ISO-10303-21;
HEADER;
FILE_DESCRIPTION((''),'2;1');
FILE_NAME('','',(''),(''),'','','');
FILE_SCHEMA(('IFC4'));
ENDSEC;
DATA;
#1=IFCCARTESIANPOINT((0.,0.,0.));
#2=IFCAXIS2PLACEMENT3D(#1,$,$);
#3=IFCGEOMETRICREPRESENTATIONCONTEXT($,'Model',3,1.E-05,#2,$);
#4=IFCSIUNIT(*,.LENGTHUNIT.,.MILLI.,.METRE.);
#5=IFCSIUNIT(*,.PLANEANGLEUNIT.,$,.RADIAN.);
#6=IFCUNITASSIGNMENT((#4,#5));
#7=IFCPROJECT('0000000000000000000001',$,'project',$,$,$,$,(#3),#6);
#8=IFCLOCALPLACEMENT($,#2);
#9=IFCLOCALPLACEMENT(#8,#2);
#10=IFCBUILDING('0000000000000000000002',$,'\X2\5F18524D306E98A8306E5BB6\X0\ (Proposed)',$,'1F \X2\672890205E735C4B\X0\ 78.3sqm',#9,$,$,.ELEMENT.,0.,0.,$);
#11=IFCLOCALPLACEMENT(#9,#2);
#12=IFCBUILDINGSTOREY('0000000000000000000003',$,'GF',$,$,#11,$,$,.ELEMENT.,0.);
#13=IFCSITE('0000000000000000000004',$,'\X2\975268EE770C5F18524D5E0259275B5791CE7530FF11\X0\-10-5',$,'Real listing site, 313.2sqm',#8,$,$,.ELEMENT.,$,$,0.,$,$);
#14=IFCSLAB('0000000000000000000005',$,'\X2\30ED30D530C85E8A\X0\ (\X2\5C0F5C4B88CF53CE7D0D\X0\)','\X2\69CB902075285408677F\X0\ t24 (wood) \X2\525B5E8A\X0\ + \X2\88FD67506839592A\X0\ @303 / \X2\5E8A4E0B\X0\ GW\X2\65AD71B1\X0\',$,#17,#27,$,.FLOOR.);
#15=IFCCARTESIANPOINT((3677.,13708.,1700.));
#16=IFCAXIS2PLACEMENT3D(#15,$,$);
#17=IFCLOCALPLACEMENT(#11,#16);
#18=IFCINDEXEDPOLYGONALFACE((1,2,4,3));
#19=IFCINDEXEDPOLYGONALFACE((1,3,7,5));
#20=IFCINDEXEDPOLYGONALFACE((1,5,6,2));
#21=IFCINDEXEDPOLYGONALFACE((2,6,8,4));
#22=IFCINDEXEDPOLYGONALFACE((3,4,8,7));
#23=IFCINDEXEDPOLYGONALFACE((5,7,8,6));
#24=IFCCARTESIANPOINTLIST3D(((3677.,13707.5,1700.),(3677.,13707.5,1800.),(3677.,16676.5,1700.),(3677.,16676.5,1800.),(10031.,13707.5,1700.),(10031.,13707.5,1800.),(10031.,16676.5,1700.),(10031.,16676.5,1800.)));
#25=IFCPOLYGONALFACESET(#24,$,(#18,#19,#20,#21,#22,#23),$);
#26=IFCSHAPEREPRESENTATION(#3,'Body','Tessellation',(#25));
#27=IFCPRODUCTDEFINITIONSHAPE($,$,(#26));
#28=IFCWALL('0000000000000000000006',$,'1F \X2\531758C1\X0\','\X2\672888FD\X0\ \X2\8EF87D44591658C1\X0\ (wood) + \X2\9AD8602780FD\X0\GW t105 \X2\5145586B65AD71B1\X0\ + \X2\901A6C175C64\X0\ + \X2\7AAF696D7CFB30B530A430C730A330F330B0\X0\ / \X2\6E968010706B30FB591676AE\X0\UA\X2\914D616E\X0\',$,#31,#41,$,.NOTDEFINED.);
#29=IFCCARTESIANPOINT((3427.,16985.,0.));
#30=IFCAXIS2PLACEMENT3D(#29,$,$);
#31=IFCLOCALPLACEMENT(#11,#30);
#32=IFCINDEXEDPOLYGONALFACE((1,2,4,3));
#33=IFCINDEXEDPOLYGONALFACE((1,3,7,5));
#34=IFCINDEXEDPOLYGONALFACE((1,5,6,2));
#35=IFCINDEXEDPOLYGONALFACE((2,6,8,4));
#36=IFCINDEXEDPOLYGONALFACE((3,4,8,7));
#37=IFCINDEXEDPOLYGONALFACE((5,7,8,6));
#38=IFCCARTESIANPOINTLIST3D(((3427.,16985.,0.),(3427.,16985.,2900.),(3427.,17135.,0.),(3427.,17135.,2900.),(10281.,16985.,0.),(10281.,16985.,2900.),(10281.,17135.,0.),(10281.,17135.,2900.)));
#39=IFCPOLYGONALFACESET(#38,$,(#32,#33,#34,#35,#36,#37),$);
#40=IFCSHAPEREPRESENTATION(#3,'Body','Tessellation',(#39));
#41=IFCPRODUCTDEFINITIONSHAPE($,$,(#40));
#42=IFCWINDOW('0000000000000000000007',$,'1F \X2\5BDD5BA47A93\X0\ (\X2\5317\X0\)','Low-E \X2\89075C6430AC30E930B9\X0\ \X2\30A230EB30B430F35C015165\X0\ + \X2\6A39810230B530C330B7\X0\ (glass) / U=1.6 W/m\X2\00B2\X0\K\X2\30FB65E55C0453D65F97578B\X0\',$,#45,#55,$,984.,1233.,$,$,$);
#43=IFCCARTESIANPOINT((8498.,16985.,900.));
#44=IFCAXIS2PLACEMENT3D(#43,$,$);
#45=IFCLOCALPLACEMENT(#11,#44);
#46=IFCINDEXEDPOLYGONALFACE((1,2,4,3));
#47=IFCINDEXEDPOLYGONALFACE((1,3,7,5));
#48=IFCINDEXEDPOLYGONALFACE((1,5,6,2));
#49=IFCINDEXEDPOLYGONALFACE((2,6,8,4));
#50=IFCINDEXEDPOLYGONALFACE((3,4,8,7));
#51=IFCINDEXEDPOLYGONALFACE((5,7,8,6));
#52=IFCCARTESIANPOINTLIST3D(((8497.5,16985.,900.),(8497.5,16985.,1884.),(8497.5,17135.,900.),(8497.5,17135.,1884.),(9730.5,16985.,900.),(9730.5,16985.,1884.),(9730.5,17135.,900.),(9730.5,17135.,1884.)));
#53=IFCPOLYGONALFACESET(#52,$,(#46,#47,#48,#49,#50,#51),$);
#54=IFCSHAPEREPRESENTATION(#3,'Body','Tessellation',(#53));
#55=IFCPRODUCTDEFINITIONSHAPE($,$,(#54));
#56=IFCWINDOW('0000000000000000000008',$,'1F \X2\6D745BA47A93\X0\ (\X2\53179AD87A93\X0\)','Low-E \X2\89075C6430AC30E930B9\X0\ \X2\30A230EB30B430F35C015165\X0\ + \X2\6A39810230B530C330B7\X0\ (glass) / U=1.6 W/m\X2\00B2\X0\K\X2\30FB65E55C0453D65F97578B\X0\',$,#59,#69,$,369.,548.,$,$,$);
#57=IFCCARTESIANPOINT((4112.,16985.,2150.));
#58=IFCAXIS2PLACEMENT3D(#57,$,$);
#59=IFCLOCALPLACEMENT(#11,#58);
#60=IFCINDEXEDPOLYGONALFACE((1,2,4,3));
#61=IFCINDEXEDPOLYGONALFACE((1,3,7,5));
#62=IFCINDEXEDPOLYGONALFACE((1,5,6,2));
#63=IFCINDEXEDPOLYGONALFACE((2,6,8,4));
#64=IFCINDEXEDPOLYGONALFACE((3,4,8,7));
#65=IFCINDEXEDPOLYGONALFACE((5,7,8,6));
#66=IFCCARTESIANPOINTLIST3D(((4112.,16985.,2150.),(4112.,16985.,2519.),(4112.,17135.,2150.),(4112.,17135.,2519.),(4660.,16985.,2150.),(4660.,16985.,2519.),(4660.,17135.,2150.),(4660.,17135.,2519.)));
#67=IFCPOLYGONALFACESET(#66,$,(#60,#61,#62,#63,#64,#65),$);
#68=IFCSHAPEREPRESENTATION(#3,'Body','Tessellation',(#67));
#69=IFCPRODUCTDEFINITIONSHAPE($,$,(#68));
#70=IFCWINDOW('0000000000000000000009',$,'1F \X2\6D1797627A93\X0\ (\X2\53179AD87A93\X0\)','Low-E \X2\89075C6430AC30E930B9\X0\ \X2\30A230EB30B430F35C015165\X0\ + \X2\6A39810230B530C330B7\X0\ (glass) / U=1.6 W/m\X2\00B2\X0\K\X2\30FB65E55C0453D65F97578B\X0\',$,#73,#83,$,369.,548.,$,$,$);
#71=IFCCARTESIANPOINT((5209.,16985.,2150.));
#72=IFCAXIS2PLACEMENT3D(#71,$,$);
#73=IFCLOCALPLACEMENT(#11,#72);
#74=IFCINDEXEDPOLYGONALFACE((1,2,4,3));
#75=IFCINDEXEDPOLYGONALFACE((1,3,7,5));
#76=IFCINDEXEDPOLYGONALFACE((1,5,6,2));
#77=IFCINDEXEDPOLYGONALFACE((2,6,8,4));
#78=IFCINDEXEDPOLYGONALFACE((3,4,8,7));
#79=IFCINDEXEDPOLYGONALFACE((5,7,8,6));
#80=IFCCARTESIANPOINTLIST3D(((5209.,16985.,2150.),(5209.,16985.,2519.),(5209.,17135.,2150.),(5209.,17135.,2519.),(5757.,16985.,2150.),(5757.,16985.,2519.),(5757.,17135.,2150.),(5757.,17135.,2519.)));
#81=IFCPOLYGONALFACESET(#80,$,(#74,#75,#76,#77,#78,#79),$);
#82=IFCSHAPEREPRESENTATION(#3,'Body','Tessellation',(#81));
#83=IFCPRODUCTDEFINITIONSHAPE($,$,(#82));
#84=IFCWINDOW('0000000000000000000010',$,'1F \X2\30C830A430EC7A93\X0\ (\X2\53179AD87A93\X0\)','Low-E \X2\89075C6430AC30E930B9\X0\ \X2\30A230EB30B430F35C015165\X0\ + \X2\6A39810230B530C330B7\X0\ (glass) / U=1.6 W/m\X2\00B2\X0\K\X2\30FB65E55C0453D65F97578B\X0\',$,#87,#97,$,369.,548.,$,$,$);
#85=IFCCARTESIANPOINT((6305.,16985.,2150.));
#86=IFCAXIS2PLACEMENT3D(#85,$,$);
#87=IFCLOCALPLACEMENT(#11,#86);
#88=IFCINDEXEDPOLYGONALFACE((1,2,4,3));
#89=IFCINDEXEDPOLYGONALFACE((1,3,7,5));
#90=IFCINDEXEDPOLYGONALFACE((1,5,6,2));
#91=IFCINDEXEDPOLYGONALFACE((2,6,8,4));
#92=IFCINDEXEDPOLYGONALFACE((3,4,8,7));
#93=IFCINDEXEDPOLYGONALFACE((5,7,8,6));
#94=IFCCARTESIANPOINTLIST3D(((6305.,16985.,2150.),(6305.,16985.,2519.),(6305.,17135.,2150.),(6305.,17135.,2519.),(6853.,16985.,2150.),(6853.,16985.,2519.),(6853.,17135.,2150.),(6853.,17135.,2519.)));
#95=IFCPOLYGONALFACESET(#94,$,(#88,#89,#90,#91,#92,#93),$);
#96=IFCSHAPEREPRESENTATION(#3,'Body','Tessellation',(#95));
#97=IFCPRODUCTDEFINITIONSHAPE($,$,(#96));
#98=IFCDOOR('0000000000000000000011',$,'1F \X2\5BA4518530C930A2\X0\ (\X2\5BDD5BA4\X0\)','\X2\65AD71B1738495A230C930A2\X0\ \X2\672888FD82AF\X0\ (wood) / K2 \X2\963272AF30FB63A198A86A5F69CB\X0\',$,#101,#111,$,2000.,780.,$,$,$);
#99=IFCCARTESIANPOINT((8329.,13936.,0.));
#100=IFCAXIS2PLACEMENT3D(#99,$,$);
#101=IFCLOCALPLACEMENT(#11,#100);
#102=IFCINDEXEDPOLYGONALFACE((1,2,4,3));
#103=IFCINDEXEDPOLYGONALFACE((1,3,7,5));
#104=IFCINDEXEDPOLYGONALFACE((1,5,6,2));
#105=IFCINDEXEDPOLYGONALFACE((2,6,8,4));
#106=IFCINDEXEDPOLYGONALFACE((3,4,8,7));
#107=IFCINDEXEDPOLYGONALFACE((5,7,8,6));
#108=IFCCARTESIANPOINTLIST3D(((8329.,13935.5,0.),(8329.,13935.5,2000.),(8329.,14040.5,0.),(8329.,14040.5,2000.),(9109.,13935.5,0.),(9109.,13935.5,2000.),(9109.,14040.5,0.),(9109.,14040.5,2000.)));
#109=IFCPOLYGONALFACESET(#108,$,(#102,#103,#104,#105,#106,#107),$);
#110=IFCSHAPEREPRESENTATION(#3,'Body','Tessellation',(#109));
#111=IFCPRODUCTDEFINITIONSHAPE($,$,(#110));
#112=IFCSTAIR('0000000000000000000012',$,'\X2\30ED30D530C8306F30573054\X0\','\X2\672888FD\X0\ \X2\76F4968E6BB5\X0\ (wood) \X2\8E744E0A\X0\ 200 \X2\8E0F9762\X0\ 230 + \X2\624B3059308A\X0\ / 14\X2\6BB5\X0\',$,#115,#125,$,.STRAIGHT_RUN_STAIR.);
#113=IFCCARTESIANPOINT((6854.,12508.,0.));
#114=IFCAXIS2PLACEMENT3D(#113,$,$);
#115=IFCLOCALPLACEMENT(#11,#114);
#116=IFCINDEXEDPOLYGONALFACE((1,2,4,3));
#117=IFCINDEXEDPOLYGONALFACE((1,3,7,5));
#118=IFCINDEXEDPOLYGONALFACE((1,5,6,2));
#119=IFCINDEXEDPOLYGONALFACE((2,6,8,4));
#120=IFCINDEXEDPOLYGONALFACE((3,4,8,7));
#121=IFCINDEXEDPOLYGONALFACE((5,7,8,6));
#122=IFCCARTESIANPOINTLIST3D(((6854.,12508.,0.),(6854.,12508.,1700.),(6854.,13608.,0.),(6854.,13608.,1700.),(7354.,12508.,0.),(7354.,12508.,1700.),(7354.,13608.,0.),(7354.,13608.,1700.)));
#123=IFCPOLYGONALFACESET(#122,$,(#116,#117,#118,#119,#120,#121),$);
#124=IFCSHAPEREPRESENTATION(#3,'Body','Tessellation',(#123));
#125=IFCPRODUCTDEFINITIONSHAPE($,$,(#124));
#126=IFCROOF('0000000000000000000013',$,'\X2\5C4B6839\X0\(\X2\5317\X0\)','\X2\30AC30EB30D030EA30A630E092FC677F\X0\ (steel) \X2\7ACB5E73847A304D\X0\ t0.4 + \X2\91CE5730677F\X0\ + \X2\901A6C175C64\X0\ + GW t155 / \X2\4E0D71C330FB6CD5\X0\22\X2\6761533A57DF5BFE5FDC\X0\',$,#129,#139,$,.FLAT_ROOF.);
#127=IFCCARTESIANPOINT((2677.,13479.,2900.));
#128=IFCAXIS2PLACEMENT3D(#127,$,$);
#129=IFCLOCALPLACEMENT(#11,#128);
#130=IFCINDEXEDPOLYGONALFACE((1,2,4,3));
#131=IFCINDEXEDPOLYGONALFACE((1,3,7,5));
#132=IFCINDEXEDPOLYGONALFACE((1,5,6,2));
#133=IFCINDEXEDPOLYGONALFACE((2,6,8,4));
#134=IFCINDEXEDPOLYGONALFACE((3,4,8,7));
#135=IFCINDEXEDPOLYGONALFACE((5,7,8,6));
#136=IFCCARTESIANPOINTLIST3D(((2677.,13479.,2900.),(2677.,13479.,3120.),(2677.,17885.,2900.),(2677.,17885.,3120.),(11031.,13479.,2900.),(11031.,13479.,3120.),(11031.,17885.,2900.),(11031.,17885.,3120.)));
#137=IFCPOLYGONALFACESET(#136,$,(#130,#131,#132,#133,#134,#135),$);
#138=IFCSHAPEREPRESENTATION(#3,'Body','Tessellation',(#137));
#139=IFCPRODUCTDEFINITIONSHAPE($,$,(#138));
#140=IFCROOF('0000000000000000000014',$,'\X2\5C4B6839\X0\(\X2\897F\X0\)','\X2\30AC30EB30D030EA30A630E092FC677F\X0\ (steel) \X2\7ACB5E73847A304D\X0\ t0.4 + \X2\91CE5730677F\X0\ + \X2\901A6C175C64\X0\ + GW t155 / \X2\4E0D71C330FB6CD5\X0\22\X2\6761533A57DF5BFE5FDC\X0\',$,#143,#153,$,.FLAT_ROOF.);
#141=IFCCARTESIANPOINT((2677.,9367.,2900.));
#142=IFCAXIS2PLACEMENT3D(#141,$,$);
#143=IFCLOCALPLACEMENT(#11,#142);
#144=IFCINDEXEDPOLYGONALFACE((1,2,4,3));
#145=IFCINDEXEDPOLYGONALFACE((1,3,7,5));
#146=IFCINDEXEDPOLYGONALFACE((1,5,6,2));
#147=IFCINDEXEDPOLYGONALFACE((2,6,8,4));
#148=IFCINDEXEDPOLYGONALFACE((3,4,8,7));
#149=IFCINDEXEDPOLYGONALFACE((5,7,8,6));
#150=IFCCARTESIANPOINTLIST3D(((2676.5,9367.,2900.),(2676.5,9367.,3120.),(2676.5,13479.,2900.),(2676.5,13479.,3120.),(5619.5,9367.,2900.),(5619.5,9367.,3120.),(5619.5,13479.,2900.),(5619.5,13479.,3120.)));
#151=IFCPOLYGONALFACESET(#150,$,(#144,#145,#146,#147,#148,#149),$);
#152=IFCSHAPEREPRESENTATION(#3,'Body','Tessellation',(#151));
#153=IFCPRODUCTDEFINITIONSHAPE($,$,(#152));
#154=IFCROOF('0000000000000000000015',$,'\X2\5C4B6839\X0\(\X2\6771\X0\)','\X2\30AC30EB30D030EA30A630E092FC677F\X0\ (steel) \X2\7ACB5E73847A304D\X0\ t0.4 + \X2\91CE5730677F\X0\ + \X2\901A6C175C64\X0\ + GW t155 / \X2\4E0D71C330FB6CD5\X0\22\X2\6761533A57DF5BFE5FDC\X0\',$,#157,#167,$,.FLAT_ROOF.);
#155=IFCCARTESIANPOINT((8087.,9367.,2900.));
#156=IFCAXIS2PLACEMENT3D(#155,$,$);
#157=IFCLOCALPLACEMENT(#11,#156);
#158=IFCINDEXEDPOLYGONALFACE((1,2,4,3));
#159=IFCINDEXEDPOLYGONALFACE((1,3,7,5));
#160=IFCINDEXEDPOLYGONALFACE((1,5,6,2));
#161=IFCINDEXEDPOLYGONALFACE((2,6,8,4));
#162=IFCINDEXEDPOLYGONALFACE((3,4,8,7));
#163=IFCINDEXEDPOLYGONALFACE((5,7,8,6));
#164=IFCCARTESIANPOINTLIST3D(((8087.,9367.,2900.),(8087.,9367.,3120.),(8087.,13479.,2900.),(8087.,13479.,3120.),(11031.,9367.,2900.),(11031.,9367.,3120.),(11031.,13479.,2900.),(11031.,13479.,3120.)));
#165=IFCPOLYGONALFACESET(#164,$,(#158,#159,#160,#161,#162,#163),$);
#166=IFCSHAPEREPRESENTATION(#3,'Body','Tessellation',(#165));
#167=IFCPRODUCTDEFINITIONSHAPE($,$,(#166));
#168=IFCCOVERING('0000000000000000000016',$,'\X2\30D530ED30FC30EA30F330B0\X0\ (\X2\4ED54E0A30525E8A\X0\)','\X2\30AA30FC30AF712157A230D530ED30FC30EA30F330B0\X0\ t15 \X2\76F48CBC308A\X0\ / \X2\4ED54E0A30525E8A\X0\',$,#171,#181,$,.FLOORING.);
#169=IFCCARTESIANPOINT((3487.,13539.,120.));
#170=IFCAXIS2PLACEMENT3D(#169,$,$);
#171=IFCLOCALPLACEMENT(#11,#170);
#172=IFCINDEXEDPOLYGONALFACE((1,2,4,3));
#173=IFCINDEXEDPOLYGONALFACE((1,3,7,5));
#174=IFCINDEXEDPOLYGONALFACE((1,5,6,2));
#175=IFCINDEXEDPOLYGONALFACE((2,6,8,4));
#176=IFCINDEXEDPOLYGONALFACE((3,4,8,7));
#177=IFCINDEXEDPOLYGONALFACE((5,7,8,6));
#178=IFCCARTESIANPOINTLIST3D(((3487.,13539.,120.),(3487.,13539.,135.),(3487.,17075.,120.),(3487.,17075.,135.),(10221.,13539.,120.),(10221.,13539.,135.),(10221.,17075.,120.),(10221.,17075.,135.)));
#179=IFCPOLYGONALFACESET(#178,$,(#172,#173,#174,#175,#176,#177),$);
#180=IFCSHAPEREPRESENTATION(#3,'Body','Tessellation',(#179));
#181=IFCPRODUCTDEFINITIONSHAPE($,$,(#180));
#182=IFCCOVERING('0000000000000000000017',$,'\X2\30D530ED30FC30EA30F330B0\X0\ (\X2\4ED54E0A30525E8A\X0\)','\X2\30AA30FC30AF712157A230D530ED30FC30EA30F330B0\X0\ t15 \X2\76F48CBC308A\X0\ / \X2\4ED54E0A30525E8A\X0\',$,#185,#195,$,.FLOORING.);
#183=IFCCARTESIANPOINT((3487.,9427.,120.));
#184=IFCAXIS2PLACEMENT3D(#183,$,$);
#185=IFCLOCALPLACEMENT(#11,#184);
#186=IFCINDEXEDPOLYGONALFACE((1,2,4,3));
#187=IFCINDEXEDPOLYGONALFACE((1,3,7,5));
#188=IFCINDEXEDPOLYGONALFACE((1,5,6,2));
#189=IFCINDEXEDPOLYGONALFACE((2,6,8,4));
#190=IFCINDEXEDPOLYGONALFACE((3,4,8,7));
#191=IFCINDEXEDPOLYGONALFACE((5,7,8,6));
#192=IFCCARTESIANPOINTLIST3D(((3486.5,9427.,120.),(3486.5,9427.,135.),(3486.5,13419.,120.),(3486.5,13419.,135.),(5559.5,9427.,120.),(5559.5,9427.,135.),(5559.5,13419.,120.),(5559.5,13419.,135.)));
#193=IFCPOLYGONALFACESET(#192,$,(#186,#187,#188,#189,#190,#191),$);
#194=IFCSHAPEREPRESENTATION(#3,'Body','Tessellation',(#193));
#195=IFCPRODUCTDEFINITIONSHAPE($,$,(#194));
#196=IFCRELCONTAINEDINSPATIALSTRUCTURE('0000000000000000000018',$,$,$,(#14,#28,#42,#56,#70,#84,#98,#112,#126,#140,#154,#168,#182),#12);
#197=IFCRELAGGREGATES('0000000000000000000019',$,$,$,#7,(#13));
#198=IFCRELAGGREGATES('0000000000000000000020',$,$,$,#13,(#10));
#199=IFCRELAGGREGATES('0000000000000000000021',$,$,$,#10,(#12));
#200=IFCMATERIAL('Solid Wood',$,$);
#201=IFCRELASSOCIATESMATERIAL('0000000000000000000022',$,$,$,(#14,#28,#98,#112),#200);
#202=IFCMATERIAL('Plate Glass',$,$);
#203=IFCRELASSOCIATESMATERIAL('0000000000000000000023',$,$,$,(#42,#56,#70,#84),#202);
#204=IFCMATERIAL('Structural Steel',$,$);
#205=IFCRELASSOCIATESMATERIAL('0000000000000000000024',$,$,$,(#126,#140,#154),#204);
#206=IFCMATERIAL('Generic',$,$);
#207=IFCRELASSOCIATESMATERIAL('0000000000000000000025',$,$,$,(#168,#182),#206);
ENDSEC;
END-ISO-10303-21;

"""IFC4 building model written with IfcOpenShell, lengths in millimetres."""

from ifc_helpers import new_model, si_unit, frame, frame_2d, origin, place, context, project, spatial, rectangle, extrude, material, element, fill, save


model = new_model("IFC4")

# Units and contexts
model_context = context("Model", 3, precision=1e-05, world=origin())
ifc_project = project(units=[si_unit("LENGTHUNIT", "METRE", prefix="MILLI"), si_unit("PLANEANGLEUNIT", "RADIAN")], contexts=[model_context])

# Site, building, storey
site_placement = place(None, origin())
site = spatial("IfcSite", under=ifc_project, at=site_placement, Name="青森県弘前市大字野田１-10-5", ObjectType="Real listing site, 313.2sqm", CompositionType="ELEMENT", RefElevation=0.0)
building_placement = place(site_placement, origin())
building = spatial("IfcBuilding", under=site, at=building_placement, Name="弘前の風の家 (Proposed)", ObjectType="1F 木造平屋 78.3sqm", CompositionType="ELEMENT", ElevationOfRefHeight=0.0, ElevationOfTerrain=0.0)
storey_placement = place(building_placement, origin())
storey = spatial("IfcBuildingStorey", under=building, at=storey_placement, Name="GF", CompositionType="ELEMENT", Elevation=0.0)

# Slab
ifc_material_1 = material(Name="Solid Wood")
slab_1_placement = place(storey_placement, frame((3677.0, 13708.0, 1700.0)))
element("IfcSlab", 1, at=slab_1_placement, inside=storey, material=ifc_material_1, Name="ロフト床 (小屋裏収納)", Description="構造用合板 t24 (wood) 剛床 + 製材根太 @303 / 床下 GW断熱", PredefinedType="FLOOR", context=model_context, shape_type="SweptSolid", body=[
    extrude(rectangle(XDim=6354.0, YDim=2969.0, at=frame_2d((3177.0, 1484.0))), frame((3677.0, 13708.0, 1700.0)), (0.0, 0.0, 1.0), 100.0),
])

# Wall, openings, windows
wall_1_placement = place(storey_placement, frame((3427.0, 16985.0, 0.0)))
wall_1 = element("IfcWall", 2, at=wall_1_placement, inside=storey, material=ifc_material_1, Name="1F 北壁", Description="木製 軸組外壁 (wood) + 高性能GW t105 充填断熱 + 通気層 + 窯業系サイディング / 準耐火・外皮UA配慮", PredefinedType="NOTDEFINED", context=model_context, shape_type="SweptSolid", body=[
    extrude(rectangle(XDim=6854.0, YDim=150.0, at=frame_2d((3427.0, 75.0))), frame((3427.0, 16985.0, 0.0)), (0.0, 0.0, 1.0), 2900.0),
])
opening_1_placement = place(storey_placement, frame((8498.0, 16985.0, 900.0)))
opening_1 = element("IfcOpeningElement", 3, at=opening_1_placement, cuts=wall_1, PredefinedType="NOTDEFINED", context=model_context, shape_type="SweptSolid", body=[
    extrude(rectangle(XDim=1233.0, YDim=150.0, at=frame_2d((616.0, 75.0))), frame((8498.0, 16985.0, 900.0)), (0.0, 0.0, 1.0), 984.0),
])
opening_2_placement = place(storey_placement, frame((4112.0, 16985.0, 2150.0)))
opening_2 = element("IfcOpeningElement", 4, at=opening_2_placement, cuts=wall_1, PredefinedType="NOTDEFINED", context=model_context, shape_type="SweptSolid", body=[
    extrude(rectangle(XDim=548.0, YDim=150.0, at=frame_2d((274.0, 75.0))), frame((4112.0, 16985.0, 2150.0)), (0.0, 0.0, 1.0), 369.0),
])
opening_3_placement = place(storey_placement, frame((5209.0, 16985.0, 2150.0)))
opening_3 = element("IfcOpeningElement", 5, at=opening_3_placement, cuts=wall_1, PredefinedType="NOTDEFINED", context=model_context, shape_type="SweptSolid", body=[
    extrude(rectangle(XDim=548.0, YDim=150.0, at=frame_2d((274.0, 75.0))), frame((5209.0, 16985.0, 2150.0)), (0.0, 0.0, 1.0), 369.0),
])
opening_4_placement = place(storey_placement, frame((6305.0, 16985.0, 2150.0)))
opening_4 = element("IfcOpeningElement", 6, at=opening_4_placement, cuts=wall_1, PredefinedType="NOTDEFINED", context=model_context, shape_type="SweptSolid", body=[
    extrude(rectangle(XDim=548.0, YDim=150.0, at=frame_2d((274.0, 75.0))), frame((6305.0, 16985.0, 2150.0)), (0.0, 0.0, 1.0), 369.0),
])
ifc_material_2 = material(Name="Plate Glass")
window_1_placement = place(storey_placement, frame((8498.0, 16985.0, 900.0)))
window_1 = element("IfcWindow", 7, at=window_1_placement, inside=storey, material=ifc_material_2, Name="1F 寝室窓 (北)", Description="Low-E 複層ガラス アルゴン封入 + 樹脂サッシ (glass) / U=1.6 W/m²K・日射取得型", OverallHeight=984.0, OverallWidth=1233.0, context=model_context, shape_type="SweptSolid", body=[
    extrude(rectangle(XDim=1233.0, YDim=150.0, at=frame_2d((616.0, 75.0))), frame((8498.0, 16985.0, 900.0)), (0.0, 0.0, 1.0), 984.0),
])
fill(opening_1, window_1)
window_2_placement = place(storey_placement, frame((4112.0, 16985.0, 2150.0)))
window_2 = element("IfcWindow", 8, at=window_2_placement, inside=storey, material=ifc_material_2, Name="1F 浴室窓 (北高窓)", Description="Low-E 複層ガラス アルゴン封入 + 樹脂サッシ (glass) / U=1.6 W/m²K・日射取得型", OverallHeight=369.0, OverallWidth=548.0, context=model_context, shape_type="SweptSolid", body=[
    extrude(rectangle(XDim=548.0, YDim=150.0, at=frame_2d((274.0, 75.0))), frame((4112.0, 16985.0, 2150.0)), (0.0, 0.0, 1.0), 369.0),
])
fill(opening_2, window_2)
window_3_placement = place(storey_placement, frame((5209.0, 16985.0, 2150.0)))
window_3 = element("IfcWindow", 9, at=window_3_placement, inside=storey, material=ifc_material_2, Name="1F 洗面窓 (北高窓)", Description="Low-E 複層ガラス アルゴン封入 + 樹脂サッシ (glass) / U=1.6 W/m²K・日射取得型", OverallHeight=369.0, OverallWidth=548.0, context=model_context, shape_type="SweptSolid", body=[
    extrude(rectangle(XDim=548.0, YDim=150.0, at=frame_2d((274.0, 75.0))), frame((5209.0, 16985.0, 2150.0)), (0.0, 0.0, 1.0), 369.0),
])
fill(opening_3, window_3)
window_4_placement = place(storey_placement, frame((6305.0, 16985.0, 2150.0)))
window_4 = element("IfcWindow", 10, at=window_4_placement, inside=storey, material=ifc_material_2, Name="1F トイレ窓 (北高窓)", Description="Low-E 複層ガラス アルゴン封入 + 樹脂サッシ (glass) / U=1.6 W/m²K・日射取得型", OverallHeight=369.0, OverallWidth=548.0, context=model_context, shape_type="SweptSolid", body=[
    extrude(rectangle(XDim=548.0, YDim=150.0, at=frame_2d((274.0, 75.0))), frame((6305.0, 16985.0, 2150.0)), (0.0, 0.0, 1.0), 369.0),
])
fill(opening_4, window_4)

# Door
door_1_placement = place(storey_placement, frame((8329.0, 13936.0, 0.0)))
element("IfcDoor", 11, at=door_1_placement, inside=storey, material=ifc_material_1, Name="1F 室内ドア (寝室)", Description="断熱玄関ドア 木製芯 (wood) / K2 防犯・採風機構", OverallHeight=2000.0, OverallWidth=780.0, context=model_context, shape_type="SweptSolid", body=[
    extrude(rectangle(XDim=780.0, YDim=105.0, at=frame_2d((390.0, 52.0))), frame((8329.0, 13936.0, 0.0)), (0.0, 0.0, 1.0), 2000.0),
])

# Stair
stair_placement = place(storey_placement, frame((6854.0, 12508.0, 0.0)))
element("IfcStair", 12, at=stair_placement, inside=storey, material=ifc_material_1, Name="ロフトはしご", Description="木製 直階段 (wood) 蹴上 200 踏面 230 + 手すり / 14段", PredefinedType="STRAIGHT_RUN_STAIR", context=model_context, shape_type="SweptSolid", body=[
    extrude(rectangle(XDim=500.0, YDim=1100.0, at=frame_2d((250.0, 550.0))), frame((6854.0, 12508.0, 0.0)), (0.0, 0.0, 1.0), 1700.0),
])

# Roofs
ifc_material_3 = material(Name="Structural Steel")
roof_1_placement = place(storey_placement, frame((2677.0, 13479.0, 2900.0)))
element("IfcRoof", 13, at=roof_1_placement, inside=storey, material=ifc_material_3, Name="屋根(北)", Description="ガルバリウム鋼板 (steel) 立平葺き t0.4 + 野地板 + 通気層 + GW t155 / 不燃・法22条区域対応", PredefinedType="FLAT_ROOF", context=model_context, shape_type="SweptSolid", body=[
    extrude(rectangle(XDim=8354.0, YDim=4406.0, at=frame_2d((4177.0, 2203.0))), frame((2677.0, 13479.0, 2900.0)), (0.0, 0.0, 1.0), 220.0),
])
roof_2_placement = place(storey_placement, frame((2677.0, 9367.0, 2900.0)))
element("IfcRoof", 14, at=roof_2_placement, inside=storey, material=ifc_material_3, Name="屋根(西)", Description="ガルバリウム鋼板 (steel) 立平葺き t0.4 + 野地板 + 通気層 + GW t155 / 不燃・法22条区域対応", PredefinedType="FLAT_ROOF", context=model_context, shape_type="SweptSolid", body=[
    extrude(rectangle(XDim=2943.0, YDim=4112.0, at=frame_2d((1471.0, 2056.0))), frame((2677.0, 9367.0, 2900.0)), (0.0, 0.0, 1.0), 220.0),
])
roof_3_placement = place(storey_placement, frame((8087.0, 9367.0, 2900.0)))
element("IfcRoof", 15, at=roof_3_placement, inside=storey, material=ifc_material_3, Name="屋根(東)", Description="ガルバリウム鋼板 (steel) 立平葺き t0.4 + 野地板 + 通気層 + GW t155 / 不燃・法22条区域対応", PredefinedType="FLAT_ROOF", context=model_context, shape_type="SweptSolid", body=[
    extrude(rectangle(XDim=2944.0, YDim=4112.0, at=frame_2d((1472.0, 2056.0))), frame((8087.0, 9367.0, 2900.0)), (0.0, 0.0, 1.0), 220.0),
])

# Coverings
ifc_material_4 = material(Name="Generic")
covering_1_placement = place(storey_placement, frame((3487.0, 13539.0, 120.0)))
element("IfcCovering", 16, at=covering_1_placement, inside=storey, material=ifc_material_4, Name="フローリング (仕上げ床)", Description="オーク無垢フローリング t15 直貼り / 仕上げ床", PredefinedType="FLOORING", context=model_context, shape_type="SweptSolid", body=[
    extrude(rectangle(XDim=6734.0, YDim=3536.0, at=frame_2d((3367.0, 1768.0))), frame((3487.0, 13539.0, 120.0)), (0.0, 0.0, 1.0), 15.0),
])
covering_2_placement = place(storey_placement, frame((3487.0, 9427.0, 120.0)))
element("IfcCovering", 17, at=covering_2_placement, inside=storey, material=ifc_material_4, Name="フローリング (仕上げ床)", Description="オーク無垢フローリング t15 直貼り / 仕上げ床", PredefinedType="FLOORING", context=model_context, shape_type="SweptSolid", body=[
    extrude(rectangle(XDim=2073.0, YDim=3992.0, at=frame_2d((1036.0, 1996.0))), frame((3487.0, 9427.0, 120.0)), (0.0, 0.0, 1.0), 15.0),
])

save(model, "model.ifc")
